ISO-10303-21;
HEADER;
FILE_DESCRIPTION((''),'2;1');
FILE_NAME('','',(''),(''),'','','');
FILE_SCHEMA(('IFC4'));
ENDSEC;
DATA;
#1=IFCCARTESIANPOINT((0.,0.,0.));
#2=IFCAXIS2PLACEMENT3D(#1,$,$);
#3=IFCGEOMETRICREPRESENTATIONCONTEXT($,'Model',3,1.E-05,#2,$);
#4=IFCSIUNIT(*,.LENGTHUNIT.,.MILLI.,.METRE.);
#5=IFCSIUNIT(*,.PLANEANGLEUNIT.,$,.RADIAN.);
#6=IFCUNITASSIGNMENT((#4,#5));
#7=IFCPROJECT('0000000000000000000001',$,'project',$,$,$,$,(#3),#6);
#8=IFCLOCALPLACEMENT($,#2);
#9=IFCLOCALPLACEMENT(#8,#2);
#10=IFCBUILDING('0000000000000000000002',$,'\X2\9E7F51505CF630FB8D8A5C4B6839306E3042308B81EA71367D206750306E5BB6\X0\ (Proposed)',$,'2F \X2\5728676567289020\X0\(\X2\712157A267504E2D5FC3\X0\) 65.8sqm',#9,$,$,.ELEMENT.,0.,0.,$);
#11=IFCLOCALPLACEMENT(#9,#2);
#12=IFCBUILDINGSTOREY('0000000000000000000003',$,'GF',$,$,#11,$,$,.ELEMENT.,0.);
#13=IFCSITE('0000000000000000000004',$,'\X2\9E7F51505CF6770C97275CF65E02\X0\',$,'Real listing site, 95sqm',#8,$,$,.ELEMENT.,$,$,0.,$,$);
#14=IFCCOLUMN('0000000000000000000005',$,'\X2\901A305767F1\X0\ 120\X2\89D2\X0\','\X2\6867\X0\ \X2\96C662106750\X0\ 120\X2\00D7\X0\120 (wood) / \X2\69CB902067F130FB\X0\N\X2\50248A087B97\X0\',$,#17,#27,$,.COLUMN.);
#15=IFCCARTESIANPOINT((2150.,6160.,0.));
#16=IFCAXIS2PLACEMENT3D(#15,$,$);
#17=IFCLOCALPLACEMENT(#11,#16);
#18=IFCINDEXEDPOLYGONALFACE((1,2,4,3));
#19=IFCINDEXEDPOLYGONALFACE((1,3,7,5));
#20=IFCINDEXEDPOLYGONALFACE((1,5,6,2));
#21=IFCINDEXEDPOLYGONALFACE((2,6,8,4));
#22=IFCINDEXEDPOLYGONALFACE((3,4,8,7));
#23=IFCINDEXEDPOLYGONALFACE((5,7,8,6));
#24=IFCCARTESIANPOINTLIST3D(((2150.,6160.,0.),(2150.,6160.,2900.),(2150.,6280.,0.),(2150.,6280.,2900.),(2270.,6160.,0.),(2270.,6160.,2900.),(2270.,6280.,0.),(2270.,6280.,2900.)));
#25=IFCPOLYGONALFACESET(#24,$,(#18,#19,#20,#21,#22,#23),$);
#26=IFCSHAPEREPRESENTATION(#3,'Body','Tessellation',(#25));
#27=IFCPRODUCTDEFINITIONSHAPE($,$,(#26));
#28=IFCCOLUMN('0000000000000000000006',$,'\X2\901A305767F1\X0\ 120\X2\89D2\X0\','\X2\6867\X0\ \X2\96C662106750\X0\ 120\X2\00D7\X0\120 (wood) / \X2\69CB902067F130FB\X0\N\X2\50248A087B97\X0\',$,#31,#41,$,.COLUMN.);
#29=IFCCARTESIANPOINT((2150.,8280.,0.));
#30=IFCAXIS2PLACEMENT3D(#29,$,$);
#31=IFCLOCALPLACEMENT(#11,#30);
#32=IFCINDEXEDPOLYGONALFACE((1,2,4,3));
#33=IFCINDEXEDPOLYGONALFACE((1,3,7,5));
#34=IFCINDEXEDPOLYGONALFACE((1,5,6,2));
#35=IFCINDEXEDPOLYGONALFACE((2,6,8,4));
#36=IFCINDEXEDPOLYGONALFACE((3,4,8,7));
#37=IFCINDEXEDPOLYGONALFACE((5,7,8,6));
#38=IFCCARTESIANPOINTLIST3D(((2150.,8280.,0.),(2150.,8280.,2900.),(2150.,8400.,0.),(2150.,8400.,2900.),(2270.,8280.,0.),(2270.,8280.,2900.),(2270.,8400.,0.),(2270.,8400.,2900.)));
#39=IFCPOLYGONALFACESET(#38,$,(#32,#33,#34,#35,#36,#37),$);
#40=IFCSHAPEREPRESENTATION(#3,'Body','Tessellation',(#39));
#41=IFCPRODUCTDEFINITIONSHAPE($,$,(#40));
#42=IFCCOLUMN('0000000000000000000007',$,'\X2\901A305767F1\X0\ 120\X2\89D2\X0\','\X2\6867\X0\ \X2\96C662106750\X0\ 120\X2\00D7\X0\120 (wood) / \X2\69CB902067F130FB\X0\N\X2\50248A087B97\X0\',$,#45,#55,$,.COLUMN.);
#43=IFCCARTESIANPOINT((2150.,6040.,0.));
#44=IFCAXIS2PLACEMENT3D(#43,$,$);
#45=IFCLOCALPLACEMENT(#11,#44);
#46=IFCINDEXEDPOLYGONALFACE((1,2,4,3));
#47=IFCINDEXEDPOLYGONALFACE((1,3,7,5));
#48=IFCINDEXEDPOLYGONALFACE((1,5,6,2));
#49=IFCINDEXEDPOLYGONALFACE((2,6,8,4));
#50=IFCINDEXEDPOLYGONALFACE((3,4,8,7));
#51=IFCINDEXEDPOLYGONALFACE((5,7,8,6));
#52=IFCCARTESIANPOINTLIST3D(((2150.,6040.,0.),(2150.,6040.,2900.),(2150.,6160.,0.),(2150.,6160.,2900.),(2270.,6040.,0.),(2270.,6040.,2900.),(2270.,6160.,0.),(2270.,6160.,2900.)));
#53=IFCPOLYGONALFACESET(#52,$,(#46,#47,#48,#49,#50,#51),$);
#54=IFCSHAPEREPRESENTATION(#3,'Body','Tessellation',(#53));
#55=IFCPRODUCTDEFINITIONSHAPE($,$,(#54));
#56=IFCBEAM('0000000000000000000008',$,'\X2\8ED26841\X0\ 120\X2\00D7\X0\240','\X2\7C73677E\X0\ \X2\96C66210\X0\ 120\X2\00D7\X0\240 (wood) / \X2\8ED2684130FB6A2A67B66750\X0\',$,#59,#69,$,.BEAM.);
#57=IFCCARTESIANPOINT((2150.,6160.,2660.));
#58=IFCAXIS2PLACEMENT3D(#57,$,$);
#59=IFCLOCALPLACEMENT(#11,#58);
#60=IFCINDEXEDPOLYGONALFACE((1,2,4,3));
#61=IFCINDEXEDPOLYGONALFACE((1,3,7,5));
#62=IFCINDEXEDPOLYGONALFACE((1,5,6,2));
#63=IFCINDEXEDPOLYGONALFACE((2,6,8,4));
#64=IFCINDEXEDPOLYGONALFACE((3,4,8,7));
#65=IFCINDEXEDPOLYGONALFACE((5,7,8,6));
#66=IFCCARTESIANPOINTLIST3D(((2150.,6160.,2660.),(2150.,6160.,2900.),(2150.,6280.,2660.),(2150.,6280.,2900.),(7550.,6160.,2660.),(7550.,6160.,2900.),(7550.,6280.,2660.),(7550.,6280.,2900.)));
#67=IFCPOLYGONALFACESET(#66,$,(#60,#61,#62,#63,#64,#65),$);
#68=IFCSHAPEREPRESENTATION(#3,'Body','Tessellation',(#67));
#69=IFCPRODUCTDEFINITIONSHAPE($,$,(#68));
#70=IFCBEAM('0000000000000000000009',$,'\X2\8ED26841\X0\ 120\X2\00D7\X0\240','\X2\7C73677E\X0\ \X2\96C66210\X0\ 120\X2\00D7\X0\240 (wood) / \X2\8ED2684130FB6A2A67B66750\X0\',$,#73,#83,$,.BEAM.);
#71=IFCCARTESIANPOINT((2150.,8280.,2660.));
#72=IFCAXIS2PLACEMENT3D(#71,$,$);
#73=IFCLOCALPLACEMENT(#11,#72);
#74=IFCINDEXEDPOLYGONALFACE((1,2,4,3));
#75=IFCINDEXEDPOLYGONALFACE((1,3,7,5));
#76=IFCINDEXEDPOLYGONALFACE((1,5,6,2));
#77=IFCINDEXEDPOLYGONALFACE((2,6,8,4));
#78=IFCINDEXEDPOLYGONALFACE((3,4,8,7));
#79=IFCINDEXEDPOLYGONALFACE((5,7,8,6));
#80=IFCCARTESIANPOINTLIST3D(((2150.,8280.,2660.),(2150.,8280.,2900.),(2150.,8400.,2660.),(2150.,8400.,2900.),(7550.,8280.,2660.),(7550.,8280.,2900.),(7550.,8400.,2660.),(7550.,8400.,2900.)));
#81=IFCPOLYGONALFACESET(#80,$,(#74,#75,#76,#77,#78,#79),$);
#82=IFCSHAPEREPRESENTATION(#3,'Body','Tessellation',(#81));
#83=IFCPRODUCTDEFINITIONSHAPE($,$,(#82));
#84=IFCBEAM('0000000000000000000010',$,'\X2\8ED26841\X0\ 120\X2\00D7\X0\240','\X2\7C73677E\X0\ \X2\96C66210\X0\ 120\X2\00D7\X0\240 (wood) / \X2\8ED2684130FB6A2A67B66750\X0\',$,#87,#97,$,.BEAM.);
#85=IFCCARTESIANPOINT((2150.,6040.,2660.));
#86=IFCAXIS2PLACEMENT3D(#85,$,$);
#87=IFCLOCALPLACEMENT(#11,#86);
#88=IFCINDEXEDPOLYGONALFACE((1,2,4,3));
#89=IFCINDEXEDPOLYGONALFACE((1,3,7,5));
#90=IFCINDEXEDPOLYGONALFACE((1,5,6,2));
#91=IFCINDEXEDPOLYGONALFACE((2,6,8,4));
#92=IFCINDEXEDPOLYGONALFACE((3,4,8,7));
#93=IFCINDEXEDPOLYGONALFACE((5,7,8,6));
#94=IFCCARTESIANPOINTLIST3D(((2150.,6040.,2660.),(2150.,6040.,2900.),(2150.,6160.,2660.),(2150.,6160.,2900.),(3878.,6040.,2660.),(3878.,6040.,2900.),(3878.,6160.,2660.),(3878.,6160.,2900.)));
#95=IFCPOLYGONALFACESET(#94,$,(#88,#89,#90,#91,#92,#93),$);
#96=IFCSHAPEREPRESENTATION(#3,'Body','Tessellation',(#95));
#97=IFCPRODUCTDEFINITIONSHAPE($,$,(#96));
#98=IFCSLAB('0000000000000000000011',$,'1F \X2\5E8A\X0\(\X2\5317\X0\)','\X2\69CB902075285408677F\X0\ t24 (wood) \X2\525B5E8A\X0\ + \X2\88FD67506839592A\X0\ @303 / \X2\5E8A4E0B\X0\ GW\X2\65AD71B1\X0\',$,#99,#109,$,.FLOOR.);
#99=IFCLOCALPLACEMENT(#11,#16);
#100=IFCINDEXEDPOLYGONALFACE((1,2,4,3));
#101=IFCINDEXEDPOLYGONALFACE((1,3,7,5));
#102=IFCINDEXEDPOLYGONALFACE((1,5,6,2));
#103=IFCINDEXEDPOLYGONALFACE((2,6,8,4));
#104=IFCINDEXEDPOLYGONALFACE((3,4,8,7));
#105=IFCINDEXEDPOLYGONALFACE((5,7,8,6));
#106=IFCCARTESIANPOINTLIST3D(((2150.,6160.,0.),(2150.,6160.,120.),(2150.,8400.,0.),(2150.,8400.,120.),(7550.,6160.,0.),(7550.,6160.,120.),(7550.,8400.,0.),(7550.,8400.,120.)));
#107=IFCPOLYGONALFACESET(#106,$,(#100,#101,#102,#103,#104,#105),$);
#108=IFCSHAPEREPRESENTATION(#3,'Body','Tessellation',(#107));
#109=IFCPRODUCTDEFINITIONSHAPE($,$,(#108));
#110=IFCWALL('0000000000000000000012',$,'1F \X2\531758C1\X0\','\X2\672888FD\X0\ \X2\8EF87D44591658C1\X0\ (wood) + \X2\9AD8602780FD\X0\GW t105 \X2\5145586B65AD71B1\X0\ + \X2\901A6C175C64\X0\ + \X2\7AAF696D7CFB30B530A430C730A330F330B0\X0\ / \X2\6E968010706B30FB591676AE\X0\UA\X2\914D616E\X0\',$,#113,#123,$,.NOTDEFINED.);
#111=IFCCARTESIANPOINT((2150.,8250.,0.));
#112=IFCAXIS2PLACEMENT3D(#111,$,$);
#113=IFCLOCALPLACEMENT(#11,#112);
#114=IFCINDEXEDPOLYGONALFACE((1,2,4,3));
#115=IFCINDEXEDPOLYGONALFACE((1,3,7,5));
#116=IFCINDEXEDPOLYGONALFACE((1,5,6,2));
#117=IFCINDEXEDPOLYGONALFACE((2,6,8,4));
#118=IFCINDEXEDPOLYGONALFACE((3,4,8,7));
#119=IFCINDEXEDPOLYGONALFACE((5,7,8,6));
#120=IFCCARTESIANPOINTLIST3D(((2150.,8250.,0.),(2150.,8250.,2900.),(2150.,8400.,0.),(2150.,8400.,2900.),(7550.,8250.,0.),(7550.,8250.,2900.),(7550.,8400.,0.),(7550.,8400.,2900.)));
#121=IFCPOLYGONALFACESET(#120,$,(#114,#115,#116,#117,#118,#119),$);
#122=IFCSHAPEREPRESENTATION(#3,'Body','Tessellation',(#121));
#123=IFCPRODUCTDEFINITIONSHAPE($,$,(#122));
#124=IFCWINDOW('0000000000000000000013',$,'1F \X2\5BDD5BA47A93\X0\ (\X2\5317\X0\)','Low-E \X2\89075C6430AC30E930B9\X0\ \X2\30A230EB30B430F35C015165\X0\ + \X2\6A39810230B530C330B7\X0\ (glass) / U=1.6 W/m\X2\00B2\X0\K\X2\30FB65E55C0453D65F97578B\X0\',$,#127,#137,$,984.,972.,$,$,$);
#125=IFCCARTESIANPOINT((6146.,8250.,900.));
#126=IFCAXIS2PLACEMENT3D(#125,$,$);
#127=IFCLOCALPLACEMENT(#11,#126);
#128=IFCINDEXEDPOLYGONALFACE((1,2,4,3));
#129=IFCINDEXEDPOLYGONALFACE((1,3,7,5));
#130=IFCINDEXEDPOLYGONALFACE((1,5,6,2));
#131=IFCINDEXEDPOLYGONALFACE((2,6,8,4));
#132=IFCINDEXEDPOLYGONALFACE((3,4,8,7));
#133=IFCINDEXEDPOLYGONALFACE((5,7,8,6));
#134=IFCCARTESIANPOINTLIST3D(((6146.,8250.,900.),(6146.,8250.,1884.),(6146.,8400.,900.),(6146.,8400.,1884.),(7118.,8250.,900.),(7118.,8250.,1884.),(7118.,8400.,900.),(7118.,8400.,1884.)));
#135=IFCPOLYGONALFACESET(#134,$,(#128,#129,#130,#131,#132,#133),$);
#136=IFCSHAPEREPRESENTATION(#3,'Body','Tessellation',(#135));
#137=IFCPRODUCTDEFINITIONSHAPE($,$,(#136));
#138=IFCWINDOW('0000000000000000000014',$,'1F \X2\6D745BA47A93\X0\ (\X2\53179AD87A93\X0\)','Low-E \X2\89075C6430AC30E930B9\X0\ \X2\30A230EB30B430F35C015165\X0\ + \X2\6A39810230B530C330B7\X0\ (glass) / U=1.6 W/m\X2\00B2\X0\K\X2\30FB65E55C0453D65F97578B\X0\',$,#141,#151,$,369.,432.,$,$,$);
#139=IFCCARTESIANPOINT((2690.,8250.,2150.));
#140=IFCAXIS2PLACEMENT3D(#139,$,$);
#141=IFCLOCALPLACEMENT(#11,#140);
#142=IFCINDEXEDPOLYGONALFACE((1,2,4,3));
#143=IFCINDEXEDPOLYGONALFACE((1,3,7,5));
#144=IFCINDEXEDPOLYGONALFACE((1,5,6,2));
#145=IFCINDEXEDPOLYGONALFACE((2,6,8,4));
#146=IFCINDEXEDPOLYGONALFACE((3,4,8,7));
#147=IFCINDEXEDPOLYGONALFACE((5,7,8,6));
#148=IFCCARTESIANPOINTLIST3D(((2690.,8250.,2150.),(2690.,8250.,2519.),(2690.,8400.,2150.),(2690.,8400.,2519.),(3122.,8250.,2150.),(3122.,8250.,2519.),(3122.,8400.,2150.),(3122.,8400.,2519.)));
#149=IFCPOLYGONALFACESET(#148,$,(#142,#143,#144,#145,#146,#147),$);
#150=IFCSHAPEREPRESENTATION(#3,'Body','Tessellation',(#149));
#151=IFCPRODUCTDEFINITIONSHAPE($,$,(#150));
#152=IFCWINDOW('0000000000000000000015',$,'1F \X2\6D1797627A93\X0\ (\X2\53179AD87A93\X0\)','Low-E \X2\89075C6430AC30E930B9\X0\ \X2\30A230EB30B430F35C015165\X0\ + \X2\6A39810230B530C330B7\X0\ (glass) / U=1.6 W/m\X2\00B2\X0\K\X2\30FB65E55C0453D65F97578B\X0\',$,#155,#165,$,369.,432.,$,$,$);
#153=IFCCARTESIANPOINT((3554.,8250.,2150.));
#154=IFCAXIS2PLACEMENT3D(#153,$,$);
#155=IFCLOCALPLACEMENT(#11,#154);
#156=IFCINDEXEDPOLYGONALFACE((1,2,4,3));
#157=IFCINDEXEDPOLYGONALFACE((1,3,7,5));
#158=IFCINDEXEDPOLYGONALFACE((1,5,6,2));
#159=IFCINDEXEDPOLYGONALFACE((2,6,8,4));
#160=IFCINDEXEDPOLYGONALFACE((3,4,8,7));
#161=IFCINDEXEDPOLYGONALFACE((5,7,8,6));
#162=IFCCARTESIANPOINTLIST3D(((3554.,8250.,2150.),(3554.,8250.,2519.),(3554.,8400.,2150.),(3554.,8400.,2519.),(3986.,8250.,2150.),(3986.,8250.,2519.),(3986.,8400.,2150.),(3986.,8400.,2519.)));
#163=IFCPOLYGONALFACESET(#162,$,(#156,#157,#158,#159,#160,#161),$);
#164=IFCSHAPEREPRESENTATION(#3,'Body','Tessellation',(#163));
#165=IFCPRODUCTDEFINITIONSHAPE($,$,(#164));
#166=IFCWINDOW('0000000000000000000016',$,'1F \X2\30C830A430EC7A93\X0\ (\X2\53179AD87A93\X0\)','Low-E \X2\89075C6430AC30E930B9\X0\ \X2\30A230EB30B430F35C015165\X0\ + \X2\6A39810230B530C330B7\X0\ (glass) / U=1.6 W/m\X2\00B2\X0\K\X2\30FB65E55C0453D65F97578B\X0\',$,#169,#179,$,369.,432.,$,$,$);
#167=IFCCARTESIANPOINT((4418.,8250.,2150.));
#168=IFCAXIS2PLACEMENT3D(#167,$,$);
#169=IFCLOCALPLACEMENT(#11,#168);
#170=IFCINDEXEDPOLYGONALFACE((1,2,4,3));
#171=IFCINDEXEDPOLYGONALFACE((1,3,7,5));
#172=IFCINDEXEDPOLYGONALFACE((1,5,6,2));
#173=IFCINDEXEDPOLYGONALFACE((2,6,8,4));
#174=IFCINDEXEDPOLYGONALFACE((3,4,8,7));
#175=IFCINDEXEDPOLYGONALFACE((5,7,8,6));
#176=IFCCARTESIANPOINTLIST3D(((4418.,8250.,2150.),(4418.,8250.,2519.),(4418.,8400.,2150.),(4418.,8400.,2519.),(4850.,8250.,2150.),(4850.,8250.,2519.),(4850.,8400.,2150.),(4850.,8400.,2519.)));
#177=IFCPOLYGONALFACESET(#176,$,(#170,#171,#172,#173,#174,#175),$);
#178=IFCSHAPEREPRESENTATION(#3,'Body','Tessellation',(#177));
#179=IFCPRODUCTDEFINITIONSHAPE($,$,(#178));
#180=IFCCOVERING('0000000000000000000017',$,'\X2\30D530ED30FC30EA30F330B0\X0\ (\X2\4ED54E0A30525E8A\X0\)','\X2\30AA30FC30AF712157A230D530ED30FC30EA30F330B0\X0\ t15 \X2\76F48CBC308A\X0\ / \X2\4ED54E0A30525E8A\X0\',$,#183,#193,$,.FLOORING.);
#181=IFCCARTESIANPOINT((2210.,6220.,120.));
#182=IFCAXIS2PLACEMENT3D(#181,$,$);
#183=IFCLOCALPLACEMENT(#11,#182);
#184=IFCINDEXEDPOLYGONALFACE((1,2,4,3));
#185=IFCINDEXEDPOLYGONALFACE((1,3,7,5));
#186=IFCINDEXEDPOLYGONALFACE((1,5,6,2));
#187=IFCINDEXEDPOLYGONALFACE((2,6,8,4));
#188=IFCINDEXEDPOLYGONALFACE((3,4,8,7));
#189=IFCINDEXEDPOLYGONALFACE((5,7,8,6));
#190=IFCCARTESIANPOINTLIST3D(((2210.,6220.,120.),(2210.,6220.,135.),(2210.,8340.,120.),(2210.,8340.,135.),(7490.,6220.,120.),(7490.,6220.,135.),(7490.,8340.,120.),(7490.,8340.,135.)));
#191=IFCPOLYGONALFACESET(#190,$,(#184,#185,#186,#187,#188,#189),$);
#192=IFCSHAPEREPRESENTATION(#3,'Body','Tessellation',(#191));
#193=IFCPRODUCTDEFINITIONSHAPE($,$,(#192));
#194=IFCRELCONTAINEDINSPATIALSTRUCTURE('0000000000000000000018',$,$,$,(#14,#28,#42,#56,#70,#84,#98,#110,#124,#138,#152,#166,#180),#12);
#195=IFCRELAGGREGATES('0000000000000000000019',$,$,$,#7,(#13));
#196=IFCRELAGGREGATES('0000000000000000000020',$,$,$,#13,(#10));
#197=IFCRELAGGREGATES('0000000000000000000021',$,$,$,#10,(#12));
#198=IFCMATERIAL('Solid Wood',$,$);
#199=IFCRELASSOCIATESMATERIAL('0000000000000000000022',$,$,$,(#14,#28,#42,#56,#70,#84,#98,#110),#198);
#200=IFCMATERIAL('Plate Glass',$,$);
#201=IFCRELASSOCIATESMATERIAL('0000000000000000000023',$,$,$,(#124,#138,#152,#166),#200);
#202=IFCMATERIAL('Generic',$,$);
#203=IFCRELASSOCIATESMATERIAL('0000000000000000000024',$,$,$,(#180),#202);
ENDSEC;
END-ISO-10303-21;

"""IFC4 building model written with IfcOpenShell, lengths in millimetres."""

from ifc_helpers import new_model, si_unit, frame, frame_2d, origin, place, context, project, spatial, rectangle, extrude, material, element, fill, save


model = new_model("IFC4")

# Units and contexts
model_context = context("Model", 3, precision=1e-05, world=origin())
ifc_project = project(units=[si_unit("LENGTHUNIT", "METRE", prefix="MILLI"), si_unit("PLANEANGLEUNIT", "RADIAN")], contexts=[model_context])

# Site, building, storey
site_placement = place(None, origin())
site = spatial("IfcSite", under=ifc_project, at=site_placement, Name="鹿児島県霧島市", ObjectType="Real listing site, 95sqm", CompositionType="ELEMENT", RefElevation=0.0)
building_placement = place(site_placement, origin())
building = spatial("IfcBuilding", under=site, at=building_placement, Name="鹿児島・越屋根のある自然素材の家 (Proposed)", ObjectType="2F 在来木造(無垢材中心) 65.8sqm", CompositionType="ELEMENT", ElevationOfRefHeight=0.0, ElevationOfTerrain=0.0)
storey_placement = place(building_placement, origin())
storey = spatial("IfcBuildingStorey", under=building, at=storey_placement, Name="GF", CompositionType="ELEMENT", Elevation=0.0)

# Columns
ifc_material_1 = material(Name="Solid Wood")
column_1_placement = place(storey_placement, frame((2150.0, 6160.0, 0.0)))
element("IfcColumn", 1, at=column_1_placement, inside=storey, material=ifc_material_1, Name="通し柱 120角", Description="桧 集成材 120×120 (wood) / 構造柱・N値計算", PredefinedType="COLUMN", context=model_context, shape_type="SweptSolid", body=[
    extrude(rectangle(XDim=120.0, YDim=120.0, at=frame_2d((60.0, 60.0))), frame((2150.0, 6160.0, 0.0)), (0.0, 0.0, 1.0), 2900.0),
])
column_2_placement = place(storey_placement, frame((2150.0, 8280.0, 0.0)))
element("IfcColumn", 2, at=column_2_placement, inside=storey, material=ifc_material_1, Name="通し柱 120角", Description="桧 集成材 120×120 (wood) / 構造柱・N値計算", PredefinedType="COLUMN", context=model_context, shape_type="SweptSolid", body=[
    extrude(rectangle(XDim=120.0, YDim=120.0, at=frame_2d((60.0, 60.0))), frame((2150.0, 8280.0, 0.0)), (0.0, 0.0, 1.0), 2900.0),
])
column_3_placement = place(storey_placement, frame((2150.0, 6040.0, 0.0)))
element("IfcColumn", 3, at=column_3_placement, inside=storey, material=ifc_material_1, Name="通し柱 120角", Description="桧 集成材 120×120 (wood) / 構造柱・N値計算", PredefinedType="COLUMN", context=model_context, shape_type="SweptSolid", body=[
    extrude(rectangle(XDim=120.0, YDim=120.0, at=frame_2d((60.0, 60.0))), frame((2150.0, 6040.0, 0.0)), (0.0, 0.0, 1.0), 2900.0),
])

# Beams
beam_1_placement = place(storey_placement, frame((2150.0, 6160.0, 2660.0)))
element("IfcBeam", 4, at=beam_1_placement, inside=storey, material=ifc_material_1, Name="軒桁 120×240", Description="米松 集成 120×240 (wood) / 軒桁・横架材", PredefinedType="BEAM", context=model_context, shape_type="SweptSolid", body=[
    extrude(rectangle(XDim=5400.0, YDim=120.0, at=frame_2d((2700.0, 60.0))), frame((2150.0, 6160.0, 2660.0)), (0.0, 0.0, 1.0), 240.0),
])
beam_2_placement = place(storey_placement, frame((2150.0, 8280.0, 2660.0)))
element("IfcBeam", 5, at=beam_2_placement, inside=storey, material=ifc_material_1, Name="軒桁 120×240", Description="米松 集成 120×240 (wood) / 軒桁・横架材", PredefinedType="BEAM", context=model_context, shape_type="SweptSolid", body=[
    extrude(rectangle(XDim=5400.0, YDim=120.0, at=frame_2d((2700.0, 60.0))), frame((2150.0, 8280.0, 2660.0)), (0.0, 0.0, 1.0), 240.0),
])
beam_3_placement = place(storey_placement, frame((2150.0, 6040.0, 2660.0)))
element("IfcBeam", 6, at=beam_3_placement, inside=storey, material=ifc_material_1, Name="軒桁 120×240", Description="米松 集成 120×240 (wood) / 軒桁・横架材", PredefinedType="BEAM", context=model_context, shape_type="SweptSolid", body=[
    extrude(rectangle(XDim=1728.0, YDim=120.0, at=frame_2d((864.0, 60.0))), frame((2150.0, 6040.0, 2660.0)), (0.0, 0.0, 1.0), 240.0),
])

# Slab
slab_placement = place(storey_placement, frame((2150.0, 6160.0, 0.0)))
element("IfcSlab", 7, at=slab_placement, inside=storey, material=ifc_material_1, Name="1F 床(北)", Description="構造用合板 t24 (wood) 剛床 + 製材根太 @303 / 床下 GW断熱", PredefinedType="FLOOR", context=model_context, shape_type="SweptSolid", body=[
    extrude(rectangle(XDim=5400.0, YDim=2240.0, at=frame_2d((2700.0, 1120.0))), frame((2150.0, 6160.0, 0.0)), (0.0, 0.0, 1.0), 120.0),
])

# Wall, openings, windows
wall_1_placement = place(storey_placement, frame((2150.0, 8250.0, 0.0)))
wall_1 = element("IfcWall", 8, at=wall_1_placement, inside=storey, material=ifc_material_1, Name="1F 北壁", Description="木製 軸組外壁 (wood) + 高性能GW t105 充填断熱 + 通気層 + 窯業系サイディング / 準耐火・外皮UA配慮", PredefinedType="NOTDEFINED", context=model_context, shape_type="SweptSolid", body=[
    extrude(rectangle(XDim=5400.0, YDim=150.0, at=frame_2d((2700.0, 75.0))), frame((2150.0, 8250.0, 0.0)), (0.0, 0.0, 1.0), 2900.0),
])
opening_1_placement = place(storey_placement, frame((6146.0, 8250.0, 900.0)))
opening_1 = element("IfcOpeningElement", 9, at=opening_1_placement, cuts=wall_1, PredefinedType="NOTDEFINED", context=model_context, shape_type="SweptSolid", body=[
    extrude(rectangle(XDim=972.0, YDim=150.0, at=frame_2d((486.0, 75.0))), frame((6146.0, 8250.0, 900.0)), (0.0, 0.0, 1.0), 984.0),
])
opening_2_placement = place(storey_placement, frame((2690.0, 8250.0, 2150.0)))
opening_2 = element("IfcOpeningElement", 10, at=opening_2_placement, cuts=wall_1, PredefinedType="NOTDEFINED", context=model_context, shape_type="SweptSolid", body=[
    extrude(rectangle(XDim=432.0, YDim=150.0, at=frame_2d((216.0, 75.0))), frame((2690.0, 8250.0, 2150.0)), (0.0, 0.0, 1.0), 369.0),
])
opening_3_placement = place(storey_placement, frame((3554.0, 8250.0, 2150.0)))
opening_3 = element("IfcOpeningElement", 11, at=opening_3_placement, cuts=wall_1, PredefinedType="NOTDEFINED", context=model_context, shape_type="SweptSolid", body=[
    extrude(rectangle(XDim=432.0, YDim=150.0, at=frame_2d((216.0, 75.0))), frame((3554.0, 8250.0, 2150.0)), (0.0, 0.0, 1.0), 369.0),
])
opening_4_placement = place(storey_placement, frame((4418.0, 8250.0, 2150.0)))
opening_4 = element("IfcOpeningElement", 12, at=opening_4_placement, cuts=wall_1, PredefinedType="NOTDEFINED", context=model_context, shape_type="SweptSolid", body=[
    extrude(rectangle(XDim=432.0, YDim=150.0, at=frame_2d((216.0, 75.0))), frame((4418.0, 8250.0, 2150.0)), (0.0, 0.0, 1.0), 369.0),
])
ifc_material_2 = material(Name="Plate Glass")
window_1_placement = place(storey_placement, frame((6146.0, 8250.0, 900.0)))
window_1 = element("IfcWindow", 13, at=window_1_placement, inside=storey, material=ifc_material_2, Name="1F 寝室窓 (北)", Description="Low-E 複層ガラス アルゴン封入 + 樹脂サッシ (glass) / U=1.6 W/m²K・日射取得型", OverallHeight=984.0, OverallWidth=972.0, context=model_context, shape_type="SweptSolid", body=[
    extrude(rectangle(XDim=972.0, YDim=150.0, at=frame_2d((486.0, 75.0))), frame((6146.0, 8250.0, 900.0)), (0.0, 0.0, 1.0), 984.0),
])
fill(opening_1, window_1)
window_2_placement = place(storey_placement, frame((2690.0, 8250.0, 2150.0)))
window_2 = element("IfcWindow", 14, at=window_2_placement, inside=storey, material=ifc_material_2, Name="1F 浴室窓 (北高窓)", Description="Low-E 複層ガラス アルゴン封入 + 樹脂サッシ (glass) / U=1.6 W/m²K・日射取得型", OverallHeight=369.0, OverallWidth=432.0, context=model_context, shape_type="SweptSolid", body=[
    extrude(rectangle(XDim=432.0, YDim=150.0, at=frame_2d((216.0, 75.0))), frame((2690.0, 8250.0, 2150.0)), (0.0, 0.0, 1.0), 369.0),
])
fill(opening_2, window_2)
window_3_placement = place(storey_placement, frame((3554.0, 8250.0, 2150.0)))
window_3 = element("IfcWindow", 15, at=window_3_placement, inside=storey, material=ifc_material_2, Name="1F 洗面窓 (北高窓)", Description="Low-E 複層ガラス アルゴン封入 + 樹脂サッシ (glass) / U=1.6 W/m²K・日射取得型", OverallHeight=369.0, OverallWidth=432.0, context=model_context, shape_type="SweptSolid", body=[
    extrude(rectangle(XDim=432.0, YDim=150.0, at=frame_2d((216.0, 75.0))), frame((3554.0, 8250.0, 2150.0)), (0.0, 0.0, 1.0), 369.0),
])
fill(opening_3, window_3)
window_4_placement = place(storey_placement, frame((4418.0, 8250.0, 2150.0)))
window_4 = element("IfcWindow", 16, at=window_4_placement, inside=storey, material=ifc_material_2, Name="1F トイレ窓 (北高窓)", Description="Low-E 複層ガラス アルゴン封入 + 樹脂サッシ (glass) / U=1.6 W/m²K・日射取得型", OverallHeight=369.0, OverallWidth=432.0, context=model_context, shape_type="SweptSolid", body=[
    extrude(rectangle(XDim=432.0, YDim=150.0, at=frame_2d((216.0, 75.0))), frame((4418.0, 8250.0, 2150.0)), (0.0, 0.0, 1.0), 369.0),
])
fill(opening_4, window_4)

# Covering
ifc_material_3 = material(Name="Generic")
covering_1_placement = place(storey_placement, frame((2210.0, 6220.0, 120.0)))
element("IfcCovering", 17, at=covering_1_placement, inside=storey, material=ifc_material_3, Name="フローリング (仕上げ床)", Description="オーク無垢フローリング t15 直貼り / 仕上げ床", PredefinedType="FLOORING", context=model_context, shape_type="SweptSolid", body=[
    extrude(rectangle(XDim=5280.0, YDim=2120.0, at=frame_2d((2640.0, 1060.0))), frame((2210.0, 6220.0, 120.0)), (0.0, 0.0, 1.0), 15.0),
])

save(model, "model.ifc")
